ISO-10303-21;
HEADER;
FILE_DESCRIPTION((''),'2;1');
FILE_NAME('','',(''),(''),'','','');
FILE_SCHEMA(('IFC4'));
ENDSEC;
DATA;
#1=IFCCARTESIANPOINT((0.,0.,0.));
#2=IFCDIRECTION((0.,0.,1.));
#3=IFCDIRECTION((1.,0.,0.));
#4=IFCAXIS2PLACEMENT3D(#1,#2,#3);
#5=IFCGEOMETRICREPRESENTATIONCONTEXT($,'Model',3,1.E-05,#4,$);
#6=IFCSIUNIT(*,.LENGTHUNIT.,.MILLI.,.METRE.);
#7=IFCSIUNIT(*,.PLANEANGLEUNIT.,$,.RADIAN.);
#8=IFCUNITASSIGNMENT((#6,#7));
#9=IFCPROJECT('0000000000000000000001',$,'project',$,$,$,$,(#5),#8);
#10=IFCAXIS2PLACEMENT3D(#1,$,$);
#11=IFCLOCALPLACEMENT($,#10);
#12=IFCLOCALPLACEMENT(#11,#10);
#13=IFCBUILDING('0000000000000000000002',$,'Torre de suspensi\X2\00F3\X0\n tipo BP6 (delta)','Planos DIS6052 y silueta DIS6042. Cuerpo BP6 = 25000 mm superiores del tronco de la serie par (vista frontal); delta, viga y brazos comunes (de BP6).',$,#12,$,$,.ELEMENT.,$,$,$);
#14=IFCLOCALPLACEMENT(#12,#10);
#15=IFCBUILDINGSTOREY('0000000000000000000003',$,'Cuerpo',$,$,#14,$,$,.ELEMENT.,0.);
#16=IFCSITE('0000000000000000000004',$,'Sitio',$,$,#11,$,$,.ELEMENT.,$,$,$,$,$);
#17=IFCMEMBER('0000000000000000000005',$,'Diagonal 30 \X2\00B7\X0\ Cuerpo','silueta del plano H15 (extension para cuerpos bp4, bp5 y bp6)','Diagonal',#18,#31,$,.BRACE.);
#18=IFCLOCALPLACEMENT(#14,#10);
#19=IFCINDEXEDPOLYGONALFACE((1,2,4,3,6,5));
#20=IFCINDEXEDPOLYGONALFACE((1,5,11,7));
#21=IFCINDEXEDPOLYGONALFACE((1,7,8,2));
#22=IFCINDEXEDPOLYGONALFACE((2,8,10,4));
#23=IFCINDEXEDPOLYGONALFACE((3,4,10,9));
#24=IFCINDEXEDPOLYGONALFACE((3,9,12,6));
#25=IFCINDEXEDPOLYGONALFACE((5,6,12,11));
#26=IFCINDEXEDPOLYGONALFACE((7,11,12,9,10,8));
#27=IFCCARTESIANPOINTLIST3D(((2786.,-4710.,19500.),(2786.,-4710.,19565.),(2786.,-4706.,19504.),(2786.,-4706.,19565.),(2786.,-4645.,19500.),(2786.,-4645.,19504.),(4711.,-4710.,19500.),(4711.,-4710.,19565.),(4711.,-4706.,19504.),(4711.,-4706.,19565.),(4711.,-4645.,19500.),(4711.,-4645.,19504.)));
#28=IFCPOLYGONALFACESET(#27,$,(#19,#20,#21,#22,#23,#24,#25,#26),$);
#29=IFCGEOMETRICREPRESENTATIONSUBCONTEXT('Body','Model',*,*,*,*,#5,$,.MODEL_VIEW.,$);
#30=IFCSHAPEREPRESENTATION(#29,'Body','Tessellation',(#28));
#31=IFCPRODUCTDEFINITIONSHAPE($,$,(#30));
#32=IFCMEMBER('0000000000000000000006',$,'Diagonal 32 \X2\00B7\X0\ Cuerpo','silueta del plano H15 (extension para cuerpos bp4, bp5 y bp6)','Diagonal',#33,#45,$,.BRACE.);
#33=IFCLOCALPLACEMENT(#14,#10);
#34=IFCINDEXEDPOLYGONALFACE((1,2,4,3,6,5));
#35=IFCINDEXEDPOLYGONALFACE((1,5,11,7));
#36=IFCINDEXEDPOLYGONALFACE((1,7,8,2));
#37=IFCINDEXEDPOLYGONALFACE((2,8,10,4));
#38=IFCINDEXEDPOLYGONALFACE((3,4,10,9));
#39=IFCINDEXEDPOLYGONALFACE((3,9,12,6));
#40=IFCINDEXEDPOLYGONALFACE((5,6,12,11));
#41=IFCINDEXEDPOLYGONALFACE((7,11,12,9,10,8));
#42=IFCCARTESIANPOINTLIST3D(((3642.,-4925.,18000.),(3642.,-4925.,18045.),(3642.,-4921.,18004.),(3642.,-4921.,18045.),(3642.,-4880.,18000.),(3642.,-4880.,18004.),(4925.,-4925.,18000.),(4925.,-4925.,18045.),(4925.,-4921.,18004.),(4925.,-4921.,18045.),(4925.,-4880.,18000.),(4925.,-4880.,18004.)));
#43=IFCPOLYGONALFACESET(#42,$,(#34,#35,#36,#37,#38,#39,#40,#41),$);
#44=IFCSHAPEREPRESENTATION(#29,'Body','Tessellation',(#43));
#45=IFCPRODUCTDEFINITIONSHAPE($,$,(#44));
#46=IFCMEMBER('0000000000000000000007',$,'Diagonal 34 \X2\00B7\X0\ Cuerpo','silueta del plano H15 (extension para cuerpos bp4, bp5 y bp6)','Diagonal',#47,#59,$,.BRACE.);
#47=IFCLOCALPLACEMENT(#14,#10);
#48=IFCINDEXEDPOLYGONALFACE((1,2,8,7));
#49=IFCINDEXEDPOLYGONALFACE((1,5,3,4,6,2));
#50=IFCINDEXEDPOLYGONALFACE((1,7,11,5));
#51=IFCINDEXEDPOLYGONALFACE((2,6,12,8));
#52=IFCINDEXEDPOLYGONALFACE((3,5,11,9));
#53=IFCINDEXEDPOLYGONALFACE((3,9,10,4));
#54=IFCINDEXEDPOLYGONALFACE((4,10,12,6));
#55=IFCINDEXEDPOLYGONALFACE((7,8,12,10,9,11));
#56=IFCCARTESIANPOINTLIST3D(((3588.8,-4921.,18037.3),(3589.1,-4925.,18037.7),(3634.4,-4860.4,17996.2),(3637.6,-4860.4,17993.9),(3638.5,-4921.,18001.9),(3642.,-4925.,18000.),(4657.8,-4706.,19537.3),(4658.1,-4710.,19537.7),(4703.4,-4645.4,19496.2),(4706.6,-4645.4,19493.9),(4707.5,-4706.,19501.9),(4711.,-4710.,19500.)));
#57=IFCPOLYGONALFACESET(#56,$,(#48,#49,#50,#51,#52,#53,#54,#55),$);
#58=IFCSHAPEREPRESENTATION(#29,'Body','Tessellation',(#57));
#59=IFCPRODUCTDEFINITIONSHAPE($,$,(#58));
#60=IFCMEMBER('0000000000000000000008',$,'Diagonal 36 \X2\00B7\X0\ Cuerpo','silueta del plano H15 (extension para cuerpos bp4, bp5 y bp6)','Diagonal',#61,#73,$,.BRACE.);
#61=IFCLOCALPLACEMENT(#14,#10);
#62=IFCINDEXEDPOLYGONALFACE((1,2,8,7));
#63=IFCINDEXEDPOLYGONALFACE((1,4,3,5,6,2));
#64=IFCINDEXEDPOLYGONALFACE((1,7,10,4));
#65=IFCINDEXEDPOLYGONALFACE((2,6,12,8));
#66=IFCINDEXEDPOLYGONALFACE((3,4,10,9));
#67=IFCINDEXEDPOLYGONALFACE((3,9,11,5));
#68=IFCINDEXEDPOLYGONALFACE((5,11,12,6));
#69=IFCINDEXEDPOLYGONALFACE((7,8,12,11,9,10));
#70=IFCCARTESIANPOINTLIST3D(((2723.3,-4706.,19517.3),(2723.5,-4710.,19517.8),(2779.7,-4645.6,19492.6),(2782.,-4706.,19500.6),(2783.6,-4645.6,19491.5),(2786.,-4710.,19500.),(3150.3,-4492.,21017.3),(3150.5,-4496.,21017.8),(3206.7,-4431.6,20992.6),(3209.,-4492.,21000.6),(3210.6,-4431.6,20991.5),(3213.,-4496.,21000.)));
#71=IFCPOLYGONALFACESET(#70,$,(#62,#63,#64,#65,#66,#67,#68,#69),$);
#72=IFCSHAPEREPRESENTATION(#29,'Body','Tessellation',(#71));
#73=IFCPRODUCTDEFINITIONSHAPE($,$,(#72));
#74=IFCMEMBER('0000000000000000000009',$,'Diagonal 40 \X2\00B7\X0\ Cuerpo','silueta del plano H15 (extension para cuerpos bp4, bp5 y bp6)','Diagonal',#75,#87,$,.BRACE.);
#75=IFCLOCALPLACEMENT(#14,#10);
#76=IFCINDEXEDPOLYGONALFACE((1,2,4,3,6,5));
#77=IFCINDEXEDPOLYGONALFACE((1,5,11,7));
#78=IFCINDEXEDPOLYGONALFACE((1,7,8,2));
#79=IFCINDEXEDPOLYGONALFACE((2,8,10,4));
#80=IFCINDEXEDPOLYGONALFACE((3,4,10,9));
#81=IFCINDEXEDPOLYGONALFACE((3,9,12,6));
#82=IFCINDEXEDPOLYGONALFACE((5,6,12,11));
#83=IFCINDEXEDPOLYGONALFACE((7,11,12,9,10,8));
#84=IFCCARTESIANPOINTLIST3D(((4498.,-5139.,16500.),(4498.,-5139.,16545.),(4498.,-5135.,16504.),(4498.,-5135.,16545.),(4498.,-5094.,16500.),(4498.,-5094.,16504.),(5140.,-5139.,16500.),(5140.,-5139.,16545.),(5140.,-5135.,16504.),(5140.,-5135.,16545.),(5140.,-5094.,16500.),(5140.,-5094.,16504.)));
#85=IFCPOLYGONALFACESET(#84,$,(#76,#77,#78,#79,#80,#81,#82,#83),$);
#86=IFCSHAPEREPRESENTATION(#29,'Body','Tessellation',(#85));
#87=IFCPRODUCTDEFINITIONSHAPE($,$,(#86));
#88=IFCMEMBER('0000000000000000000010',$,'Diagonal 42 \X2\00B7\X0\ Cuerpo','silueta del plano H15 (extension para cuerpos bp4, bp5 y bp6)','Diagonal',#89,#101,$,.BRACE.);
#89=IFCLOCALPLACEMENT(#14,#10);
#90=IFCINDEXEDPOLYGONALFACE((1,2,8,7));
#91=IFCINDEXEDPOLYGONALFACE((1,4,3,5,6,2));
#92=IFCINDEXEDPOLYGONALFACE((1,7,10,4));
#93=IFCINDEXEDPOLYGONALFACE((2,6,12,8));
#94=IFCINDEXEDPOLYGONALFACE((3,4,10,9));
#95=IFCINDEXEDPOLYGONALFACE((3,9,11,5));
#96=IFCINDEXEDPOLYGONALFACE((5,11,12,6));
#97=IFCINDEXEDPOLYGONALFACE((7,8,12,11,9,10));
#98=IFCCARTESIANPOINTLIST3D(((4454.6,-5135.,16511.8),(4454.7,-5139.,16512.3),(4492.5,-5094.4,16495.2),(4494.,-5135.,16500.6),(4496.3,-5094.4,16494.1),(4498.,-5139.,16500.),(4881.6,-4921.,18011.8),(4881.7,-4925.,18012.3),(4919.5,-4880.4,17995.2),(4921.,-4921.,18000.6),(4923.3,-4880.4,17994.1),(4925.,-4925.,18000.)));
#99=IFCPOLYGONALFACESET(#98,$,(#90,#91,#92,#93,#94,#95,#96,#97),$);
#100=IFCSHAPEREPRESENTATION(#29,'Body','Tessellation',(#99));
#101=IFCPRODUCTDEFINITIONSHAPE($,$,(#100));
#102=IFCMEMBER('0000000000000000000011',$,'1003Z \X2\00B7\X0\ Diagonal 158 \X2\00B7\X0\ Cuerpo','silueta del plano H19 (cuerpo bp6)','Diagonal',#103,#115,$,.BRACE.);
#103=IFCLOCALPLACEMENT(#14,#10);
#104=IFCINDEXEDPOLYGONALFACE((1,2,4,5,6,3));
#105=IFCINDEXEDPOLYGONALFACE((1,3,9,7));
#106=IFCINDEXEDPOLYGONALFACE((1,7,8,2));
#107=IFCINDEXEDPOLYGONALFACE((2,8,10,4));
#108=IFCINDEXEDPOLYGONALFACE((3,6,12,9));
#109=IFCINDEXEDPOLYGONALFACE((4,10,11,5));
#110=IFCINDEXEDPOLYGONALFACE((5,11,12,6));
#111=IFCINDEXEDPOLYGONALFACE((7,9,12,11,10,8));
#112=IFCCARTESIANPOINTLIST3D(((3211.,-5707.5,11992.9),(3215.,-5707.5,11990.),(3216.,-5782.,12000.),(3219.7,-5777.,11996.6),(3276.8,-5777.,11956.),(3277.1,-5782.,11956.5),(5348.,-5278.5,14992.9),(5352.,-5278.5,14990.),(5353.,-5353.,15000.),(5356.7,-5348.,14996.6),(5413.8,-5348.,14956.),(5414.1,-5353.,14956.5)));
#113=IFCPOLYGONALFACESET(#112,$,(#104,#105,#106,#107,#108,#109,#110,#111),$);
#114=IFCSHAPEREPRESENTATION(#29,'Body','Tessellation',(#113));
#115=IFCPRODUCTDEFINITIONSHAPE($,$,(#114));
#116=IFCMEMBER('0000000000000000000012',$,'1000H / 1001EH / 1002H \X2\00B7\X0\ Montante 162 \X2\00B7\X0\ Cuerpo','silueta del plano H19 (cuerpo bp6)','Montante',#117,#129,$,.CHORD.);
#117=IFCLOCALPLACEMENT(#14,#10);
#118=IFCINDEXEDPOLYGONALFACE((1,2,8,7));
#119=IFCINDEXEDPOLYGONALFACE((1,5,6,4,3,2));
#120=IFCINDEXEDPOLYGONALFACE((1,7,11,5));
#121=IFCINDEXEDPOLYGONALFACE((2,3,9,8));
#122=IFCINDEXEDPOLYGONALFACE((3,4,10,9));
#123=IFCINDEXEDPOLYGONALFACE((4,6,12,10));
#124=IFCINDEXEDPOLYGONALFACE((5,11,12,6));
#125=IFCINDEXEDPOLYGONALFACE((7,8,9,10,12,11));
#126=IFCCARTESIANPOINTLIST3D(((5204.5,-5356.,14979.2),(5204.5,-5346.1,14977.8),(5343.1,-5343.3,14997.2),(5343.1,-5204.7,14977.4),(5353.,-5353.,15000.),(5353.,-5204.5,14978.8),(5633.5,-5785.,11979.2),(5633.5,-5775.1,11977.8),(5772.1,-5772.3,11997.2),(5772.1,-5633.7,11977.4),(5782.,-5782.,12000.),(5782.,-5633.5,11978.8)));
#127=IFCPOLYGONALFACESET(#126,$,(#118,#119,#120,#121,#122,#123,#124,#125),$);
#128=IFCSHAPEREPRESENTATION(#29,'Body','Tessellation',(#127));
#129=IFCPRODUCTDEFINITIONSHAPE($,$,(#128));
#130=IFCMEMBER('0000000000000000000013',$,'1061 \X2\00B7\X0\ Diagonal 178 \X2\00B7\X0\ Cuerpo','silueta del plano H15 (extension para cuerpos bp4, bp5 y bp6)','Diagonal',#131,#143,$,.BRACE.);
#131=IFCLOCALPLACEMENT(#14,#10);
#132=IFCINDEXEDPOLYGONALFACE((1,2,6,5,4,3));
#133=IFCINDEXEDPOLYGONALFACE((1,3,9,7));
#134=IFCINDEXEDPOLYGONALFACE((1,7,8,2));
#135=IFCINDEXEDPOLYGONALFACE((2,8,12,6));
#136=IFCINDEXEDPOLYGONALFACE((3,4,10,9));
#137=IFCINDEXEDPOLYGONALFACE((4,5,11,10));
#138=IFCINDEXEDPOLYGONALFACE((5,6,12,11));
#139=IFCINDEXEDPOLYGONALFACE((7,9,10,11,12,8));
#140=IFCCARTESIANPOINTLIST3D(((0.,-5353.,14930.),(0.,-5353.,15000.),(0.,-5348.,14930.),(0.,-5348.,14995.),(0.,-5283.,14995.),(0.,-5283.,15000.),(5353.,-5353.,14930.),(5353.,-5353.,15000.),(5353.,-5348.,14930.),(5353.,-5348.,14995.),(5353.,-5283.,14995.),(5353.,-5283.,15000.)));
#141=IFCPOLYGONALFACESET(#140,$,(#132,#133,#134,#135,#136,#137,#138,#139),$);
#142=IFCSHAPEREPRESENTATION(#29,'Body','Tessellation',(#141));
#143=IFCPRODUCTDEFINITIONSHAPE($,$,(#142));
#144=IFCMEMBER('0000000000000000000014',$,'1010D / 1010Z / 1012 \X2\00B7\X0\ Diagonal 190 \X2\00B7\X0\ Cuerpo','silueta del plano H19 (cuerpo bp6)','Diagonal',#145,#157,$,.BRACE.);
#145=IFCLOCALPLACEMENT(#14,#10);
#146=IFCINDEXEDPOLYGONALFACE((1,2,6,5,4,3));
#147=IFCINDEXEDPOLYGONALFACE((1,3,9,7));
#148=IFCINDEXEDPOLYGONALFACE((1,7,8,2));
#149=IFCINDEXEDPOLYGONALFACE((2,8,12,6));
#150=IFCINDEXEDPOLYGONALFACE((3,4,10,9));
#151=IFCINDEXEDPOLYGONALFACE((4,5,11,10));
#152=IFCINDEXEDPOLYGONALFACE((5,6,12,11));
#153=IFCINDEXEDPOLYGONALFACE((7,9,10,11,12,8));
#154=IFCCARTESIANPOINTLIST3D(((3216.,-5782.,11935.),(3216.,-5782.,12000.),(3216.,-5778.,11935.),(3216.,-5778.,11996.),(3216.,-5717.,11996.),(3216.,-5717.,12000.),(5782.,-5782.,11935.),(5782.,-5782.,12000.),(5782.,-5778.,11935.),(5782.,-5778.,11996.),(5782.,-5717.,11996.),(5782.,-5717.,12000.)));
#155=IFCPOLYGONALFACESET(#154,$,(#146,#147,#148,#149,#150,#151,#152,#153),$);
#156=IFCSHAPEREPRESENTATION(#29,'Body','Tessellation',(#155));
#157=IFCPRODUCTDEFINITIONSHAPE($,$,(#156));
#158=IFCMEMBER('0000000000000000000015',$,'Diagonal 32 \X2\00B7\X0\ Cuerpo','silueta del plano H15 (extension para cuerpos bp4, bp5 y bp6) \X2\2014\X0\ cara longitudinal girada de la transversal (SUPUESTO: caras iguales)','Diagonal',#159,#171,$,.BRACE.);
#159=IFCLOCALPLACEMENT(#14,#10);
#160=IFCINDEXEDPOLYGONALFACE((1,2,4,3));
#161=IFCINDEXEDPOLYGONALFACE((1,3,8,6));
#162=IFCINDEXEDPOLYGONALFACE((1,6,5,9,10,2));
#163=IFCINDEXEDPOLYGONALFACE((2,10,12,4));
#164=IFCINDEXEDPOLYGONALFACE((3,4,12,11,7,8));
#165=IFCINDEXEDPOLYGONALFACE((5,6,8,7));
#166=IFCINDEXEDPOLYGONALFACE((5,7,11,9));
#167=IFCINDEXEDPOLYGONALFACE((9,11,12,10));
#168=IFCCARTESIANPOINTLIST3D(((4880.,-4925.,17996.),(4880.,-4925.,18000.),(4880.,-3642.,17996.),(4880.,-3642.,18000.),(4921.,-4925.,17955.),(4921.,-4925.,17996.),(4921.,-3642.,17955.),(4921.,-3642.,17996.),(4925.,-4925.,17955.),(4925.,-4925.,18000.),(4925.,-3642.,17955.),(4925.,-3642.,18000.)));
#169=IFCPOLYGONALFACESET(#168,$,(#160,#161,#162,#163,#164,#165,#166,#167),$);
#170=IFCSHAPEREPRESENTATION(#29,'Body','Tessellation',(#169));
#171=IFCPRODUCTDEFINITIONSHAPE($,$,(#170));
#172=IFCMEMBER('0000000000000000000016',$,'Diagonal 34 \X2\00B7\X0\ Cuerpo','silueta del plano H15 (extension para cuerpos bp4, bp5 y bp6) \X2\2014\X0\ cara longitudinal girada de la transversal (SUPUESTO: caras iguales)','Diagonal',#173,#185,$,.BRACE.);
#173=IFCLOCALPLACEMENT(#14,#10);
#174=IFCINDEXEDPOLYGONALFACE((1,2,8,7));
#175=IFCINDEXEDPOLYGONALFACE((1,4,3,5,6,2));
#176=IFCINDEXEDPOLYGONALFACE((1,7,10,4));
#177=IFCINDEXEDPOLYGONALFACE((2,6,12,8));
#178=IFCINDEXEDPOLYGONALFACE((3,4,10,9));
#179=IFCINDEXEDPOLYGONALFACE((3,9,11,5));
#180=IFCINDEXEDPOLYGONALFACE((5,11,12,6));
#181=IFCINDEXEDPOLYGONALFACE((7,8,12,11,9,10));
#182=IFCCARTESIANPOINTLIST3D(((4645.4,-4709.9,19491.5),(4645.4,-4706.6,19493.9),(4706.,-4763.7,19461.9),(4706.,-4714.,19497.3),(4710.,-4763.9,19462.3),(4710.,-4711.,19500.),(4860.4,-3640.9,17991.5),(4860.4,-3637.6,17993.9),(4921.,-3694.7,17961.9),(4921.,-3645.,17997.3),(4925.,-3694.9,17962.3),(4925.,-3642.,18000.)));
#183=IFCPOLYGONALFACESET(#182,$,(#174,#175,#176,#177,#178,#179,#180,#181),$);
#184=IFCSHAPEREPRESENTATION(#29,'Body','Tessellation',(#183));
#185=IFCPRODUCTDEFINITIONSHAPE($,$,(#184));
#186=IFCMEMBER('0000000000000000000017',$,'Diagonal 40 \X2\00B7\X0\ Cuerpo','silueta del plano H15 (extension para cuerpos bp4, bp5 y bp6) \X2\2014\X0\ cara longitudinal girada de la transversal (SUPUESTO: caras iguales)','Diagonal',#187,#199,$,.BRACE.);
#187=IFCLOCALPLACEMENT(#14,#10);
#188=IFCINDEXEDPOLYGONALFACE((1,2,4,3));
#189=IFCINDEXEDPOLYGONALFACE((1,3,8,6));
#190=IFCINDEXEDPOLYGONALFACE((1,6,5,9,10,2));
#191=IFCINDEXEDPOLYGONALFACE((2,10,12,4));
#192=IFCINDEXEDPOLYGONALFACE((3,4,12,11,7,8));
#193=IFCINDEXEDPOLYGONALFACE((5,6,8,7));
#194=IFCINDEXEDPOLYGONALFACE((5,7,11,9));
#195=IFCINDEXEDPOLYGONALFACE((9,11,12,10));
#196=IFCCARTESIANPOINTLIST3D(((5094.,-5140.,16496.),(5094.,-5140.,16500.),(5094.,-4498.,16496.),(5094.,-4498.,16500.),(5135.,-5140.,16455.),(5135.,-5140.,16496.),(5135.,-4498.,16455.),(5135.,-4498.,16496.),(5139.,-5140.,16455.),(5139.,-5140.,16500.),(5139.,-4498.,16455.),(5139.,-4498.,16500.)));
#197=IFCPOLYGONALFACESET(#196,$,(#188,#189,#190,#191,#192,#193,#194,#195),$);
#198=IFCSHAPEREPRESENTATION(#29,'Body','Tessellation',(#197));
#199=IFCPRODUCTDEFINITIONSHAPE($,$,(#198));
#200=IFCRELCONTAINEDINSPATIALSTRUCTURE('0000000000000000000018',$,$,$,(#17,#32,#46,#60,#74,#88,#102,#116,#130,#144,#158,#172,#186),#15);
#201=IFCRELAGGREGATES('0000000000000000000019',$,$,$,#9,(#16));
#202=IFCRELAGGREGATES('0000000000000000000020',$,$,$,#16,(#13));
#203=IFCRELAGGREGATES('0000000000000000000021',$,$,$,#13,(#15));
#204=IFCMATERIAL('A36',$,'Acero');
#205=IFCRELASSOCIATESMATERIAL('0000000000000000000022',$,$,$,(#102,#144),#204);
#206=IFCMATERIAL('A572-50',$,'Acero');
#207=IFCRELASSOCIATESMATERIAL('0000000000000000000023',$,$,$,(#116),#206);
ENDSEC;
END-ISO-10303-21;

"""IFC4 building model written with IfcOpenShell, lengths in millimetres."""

from ifc_helpers import new_model, si_unit, frame, frame_2d, origin, origin_with_axes, place, context, subcontext, project, spatial, l_section, extrude, material, element, save


model = new_model("IFC4")

# Units and contexts
model_context = context("Model", 3, precision=1e-05, world=origin_with_axes())
body_context = subcontext(model_context, "Body", "Model", "MODEL_VIEW")
ifc_project = project(units=[si_unit("LENGTHUNIT", "METRE", prefix="MILLI"), si_unit("PLANEANGLEUNIT", "RADIAN")], contexts=[model_context])

# Site, building, storey
site_placement = place(None, origin())
site = spatial("IfcSite", under=ifc_project, at=site_placement, Name="Sitio", CompositionType="ELEMENT")
building_placement = place(site_placement, origin())
building = spatial("IfcBuilding", under=site, at=building_placement, Name="Torre de suspensión tipo BP6 (delta)", Description="Planos DIS6052 y silueta DIS6042. Cuerpo BP6 = 25000 mm superiores del tronco de la serie par (vista frontal); delta, viga y brazos comunes (de BP6).", CompositionType="ELEMENT")
storey_placement = place(building_placement, origin())
storey = spatial("IfcBuildingStorey", under=building, at=storey_placement, Name="Cuerpo", CompositionType="ELEMENT", Elevation=0.0)

# Members
member_1_placement = place(storey_placement, frame((2786.0, -4710.0, 19500.0), z_axis=(1.0, 0.0, 0.0), x_axis=(0.0, 1.0, 0.0)))
element("IfcMember", 1, at=member_1_placement, inside=storey, Name="Diagonal 30 · Cuerpo", Description="silueta del plano H15 (extension para cuerpos bp4, bp5 y bp6)", ObjectType="Diagonal", PredefinedType="BRACE", context=body_context, shape_type="SweptSolid", body=[
    extrude(l_section(Depth=65.0, Width=65.0, Thickness=4.0, at=frame_2d((32.5, 32.5))), None, (0.0, 0.0, 1.0), 1925.0),
])
member_2_placement = place(storey_placement, frame((3642.0, -4925.0, 18000.0), z_axis=(1.0, 0.0, 0.0), x_axis=(0.0, 1.0, 0.0)))
element("IfcMember", 2, at=member_2_placement, inside=storey, Name="Diagonal 32 · Cuerpo", Description="silueta del plano H15 (extension para cuerpos bp4, bp5 y bp6)", ObjectType="Diagonal", PredefinedType="BRACE", context=body_context, shape_type="SweptSolid", body=[
    extrude(l_section(Depth=45.0, Width=45.0, Thickness=4.0, at=frame_2d((22.5, 22.5))), None, (0.0, 0.0, 1.0), 1283.0),
])
member_3_placement = place(storey_placement, frame((3642.0, -4925.0, 18000.0), z_axis=(0.576451, 0.115937, 0.808865), x_axis=(-0.067286, 0.993257, -0.094414)))
element("IfcMember", 3, at=member_3_placement, inside=storey, Name="Diagonal 34 · Cuerpo", Description="silueta del plano H15 (extension para cuerpos bp4, bp5 y bp6)", ObjectType="Diagonal", PredefinedType="BRACE", context=body_context, shape_type="SweptSolid", body=[
    extrude(l_section(Depth=65.0, Width=65.0, Thickness=4.0, at=frame_2d((32.5, 32.5))), None, (0.0, 0.0, 1.0), 1854.5),
])
member_4_placement = place(storey_placement, frame((2786.0, -4710.0, 19500.0), z_axis=(0.271248, 0.135942, 0.952861), x_axis=(-0.037219, 0.990717, -0.130747)))
element("IfcMember", 4, at=member_4_placement, inside=storey, Name="Diagonal 36 · Cuerpo", Description="silueta del plano H15 (extension para cuerpos bp4, bp5 y bp6)", ObjectType="Diagonal", PredefinedType="BRACE", context=body_context, shape_type="SweptSolid", body=[
    extrude(l_section(Depth=65.0, Width=65.0, Thickness=4.0, at=frame_2d((32.5, 32.5))), None, (0.0, 0.0, 1.0), 1574.2),
])
member_5_placement = place(storey_placement, frame((4498.0, -5139.0, 16500.0), z_axis=(1.0, 0.0, 0.0), x_axis=(0.0, 1.0, 0.0)))
element("IfcMember", 5, at=member_5_placement, inside=storey, Name="Diagonal 40 · Cuerpo", Description="silueta del plano H15 (extension para cuerpos bp4, bp5 y bp6)", ObjectType="Diagonal", PredefinedType="BRACE", context=body_context, shape_type="SweptSolid", body=[
    extrude(l_section(Depth=45.0, Width=45.0, Thickness=4.0, at=frame_2d((22.5, 22.5))), None, (0.0, 0.0, 1.0), 642.0),
])
member_6_placement = place(storey_placement, frame((4498.0, -5139.0, 16500.0), z_axis=(0.271248, 0.135942, 0.952861), x_axis=(-0.037219, 0.990717, -0.130747)))
element("IfcMember", 6, at=member_6_placement, inside=storey, Name="Diagonal 42 · Cuerpo", Description="silueta del plano H15 (extension para cuerpos bp4, bp5 y bp6)", ObjectType="Diagonal", PredefinedType="BRACE", context=body_context, shape_type="SweptSolid", body=[
    extrude(l_section(Depth=45.0, Width=45.0, Thickness=4.0, at=frame_2d((22.5, 22.5))), None, (0.0, 0.0, 1.0), 1574.2),
])
ifc_material_1 = material(Name="A36", Category="Acero")
member_7_placement = place(storey_placement, frame((5353.0, -5353.0, 15000.0), z_axis=(-0.576289, -0.115689, -0.809016), x_axis=(-0.067121, 0.993285, -0.094227)))
element("IfcMember", 7, at=member_7_placement, inside=storey, material=ifc_material_1, Name="1003Z · Diagonal 158 · Cuerpo", Description="silueta del plano H19 (cuerpo bp6)", ObjectType="Diagonal", PredefinedType="BRACE", context=body_context, shape_type="SweptSolid", body=[
    extrude(l_section(Depth=75.0, Width=75.0, Thickness=5.0, at=frame_2d((37.5, 37.5))), None, (0.0, 0.0, 1.0), 3708.2),
])
ifc_material_2 = material(Name="A572-50", Category="Acero")
member_8_placement = place(storey_placement, frame((5353.0, -5353.0, 15000.0), z_axis=(0.140163, -0.140163, -0.980158), x_axis=(-0.990129, -0.019841, -0.138751)))
element("IfcMember", 8, at=member_8_placement, inside=storey, material=ifc_material_2, Name="1000H / 1001EH / 1002H · Montante 162 · Cuerpo", Description="silueta del plano H19 (cuerpo bp6)", ObjectType="Montante", PredefinedType="CHORD", context=body_context, shape_type="SweptSolid", body=[
    extrude(l_section(Depth=150.0, Width=150.0, Thickness=10.0, at=frame_2d((75.0, 75.0))), None, (0.0, 0.0, 1.0), 3060.7),
])
member_9_placement = place(storey_placement, frame((5353.0, -5353.0, 15000.0), z_axis=(-1.0, 0.0, 0.0), x_axis=(0.0, 1.0, 0.0)))
element("IfcMember", 9, at=member_9_placement, inside=storey, Name="1061 · Diagonal 178 · Cuerpo", Description="silueta del plano H15 (extension para cuerpos bp4, bp5 y bp6)", ObjectType="Diagonal", PredefinedType="BRACE", context=body_context, shape_type="SweptSolid", body=[
    extrude(l_section(Depth=70.0, Width=70.0, Thickness=5.0, at=frame_2d((35.0, 35.0))), None, (0.0, 0.0, 1.0), 5353.0),
])
member_10_placement = place(storey_placement, frame((5782.0, -5782.0, 12000.0), z_axis=(-1.0, 0.0, 0.0), x_axis=(0.0, 1.0, 0.0)))
element("IfcMember", 10, at=member_10_placement, inside=storey, material=ifc_material_1, Name="1010D / 1010Z / 1012 · Diagonal 190 · Cuerpo", Description="silueta del plano H19 (cuerpo bp6)", ObjectType="Diagonal", PredefinedType="BRACE", context=body_context, shape_type="SweptSolid", body=[
    extrude(l_section(Depth=65.0, Width=65.0, Thickness=4.0, at=frame_2d((32.5, 32.5))), None, (0.0, 0.0, 1.0), 2566.0),
])
member_11_placement = place(storey_placement, frame((4925.0, -3642.0, 18000.0), z_axis=(0.0, -1.0, 0.0), x_axis=(-1.0, 0.0, 0.0)))
element("IfcMember", 11, at=member_11_placement, inside=storey, Name="Diagonal 32 · Cuerpo", Description="silueta del plano H15 (extension para cuerpos bp4, bp5 y bp6) — cara longitudinal girada de la transversal (SUPUESTO: caras iguales)", ObjectType="Diagonal", PredefinedType="BRACE", context=body_context, shape_type="SweptSolid", body=[
    extrude(l_section(Depth=45.0, Width=45.0, Thickness=4.0, at=frame_2d((22.5, 22.5))), None, (0.0, 0.0, 1.0), 1283.0),
])
member_12_placement = place(storey_placement, frame((4925.0, -3642.0, 18000.0), z_axis=(-0.115937, -0.576451, 0.808865), x_axis=(-0.993257, 0.067286, -0.094414)))
element("IfcMember", 12, at=member_12_placement, inside=storey, Name="Diagonal 34 · Cuerpo", Description="silueta del plano H15 (extension para cuerpos bp4, bp5 y bp6) — cara longitudinal girada de la transversal (SUPUESTO: caras iguales)", ObjectType="Diagonal", PredefinedType="BRACE", context=body_context, shape_type="SweptSolid", body=[
    extrude(l_section(Depth=65.0, Width=65.0, Thickness=4.0, at=frame_2d((32.5, 32.5))), None, (0.0, 0.0, 1.0), 1854.5),
])
member_13_placement = place(storey_placement, frame((5139.0, -4498.0, 16500.0), z_axis=(0.0, -1.0, 0.0), x_axis=(-1.0, 0.0, 0.0)))
element("IfcMember", 13, at=member_13_placement, inside=storey, Name="Diagonal 40 · Cuerpo", Description="silueta del plano H15 (extension para cuerpos bp4, bp5 y bp6) — cara longitudinal girada de la transversal (SUPUESTO: caras iguales)", ObjectType="Diagonal", PredefinedType="BRACE", context=body_context, shape_type="SweptSolid", body=[
    extrude(l_section(Depth=45.0, Width=45.0, Thickness=4.0, at=frame_2d((22.5, 22.5))), None, (0.0, 0.0, 1.0), 642.0),
])

save(model, "model.ifc")
